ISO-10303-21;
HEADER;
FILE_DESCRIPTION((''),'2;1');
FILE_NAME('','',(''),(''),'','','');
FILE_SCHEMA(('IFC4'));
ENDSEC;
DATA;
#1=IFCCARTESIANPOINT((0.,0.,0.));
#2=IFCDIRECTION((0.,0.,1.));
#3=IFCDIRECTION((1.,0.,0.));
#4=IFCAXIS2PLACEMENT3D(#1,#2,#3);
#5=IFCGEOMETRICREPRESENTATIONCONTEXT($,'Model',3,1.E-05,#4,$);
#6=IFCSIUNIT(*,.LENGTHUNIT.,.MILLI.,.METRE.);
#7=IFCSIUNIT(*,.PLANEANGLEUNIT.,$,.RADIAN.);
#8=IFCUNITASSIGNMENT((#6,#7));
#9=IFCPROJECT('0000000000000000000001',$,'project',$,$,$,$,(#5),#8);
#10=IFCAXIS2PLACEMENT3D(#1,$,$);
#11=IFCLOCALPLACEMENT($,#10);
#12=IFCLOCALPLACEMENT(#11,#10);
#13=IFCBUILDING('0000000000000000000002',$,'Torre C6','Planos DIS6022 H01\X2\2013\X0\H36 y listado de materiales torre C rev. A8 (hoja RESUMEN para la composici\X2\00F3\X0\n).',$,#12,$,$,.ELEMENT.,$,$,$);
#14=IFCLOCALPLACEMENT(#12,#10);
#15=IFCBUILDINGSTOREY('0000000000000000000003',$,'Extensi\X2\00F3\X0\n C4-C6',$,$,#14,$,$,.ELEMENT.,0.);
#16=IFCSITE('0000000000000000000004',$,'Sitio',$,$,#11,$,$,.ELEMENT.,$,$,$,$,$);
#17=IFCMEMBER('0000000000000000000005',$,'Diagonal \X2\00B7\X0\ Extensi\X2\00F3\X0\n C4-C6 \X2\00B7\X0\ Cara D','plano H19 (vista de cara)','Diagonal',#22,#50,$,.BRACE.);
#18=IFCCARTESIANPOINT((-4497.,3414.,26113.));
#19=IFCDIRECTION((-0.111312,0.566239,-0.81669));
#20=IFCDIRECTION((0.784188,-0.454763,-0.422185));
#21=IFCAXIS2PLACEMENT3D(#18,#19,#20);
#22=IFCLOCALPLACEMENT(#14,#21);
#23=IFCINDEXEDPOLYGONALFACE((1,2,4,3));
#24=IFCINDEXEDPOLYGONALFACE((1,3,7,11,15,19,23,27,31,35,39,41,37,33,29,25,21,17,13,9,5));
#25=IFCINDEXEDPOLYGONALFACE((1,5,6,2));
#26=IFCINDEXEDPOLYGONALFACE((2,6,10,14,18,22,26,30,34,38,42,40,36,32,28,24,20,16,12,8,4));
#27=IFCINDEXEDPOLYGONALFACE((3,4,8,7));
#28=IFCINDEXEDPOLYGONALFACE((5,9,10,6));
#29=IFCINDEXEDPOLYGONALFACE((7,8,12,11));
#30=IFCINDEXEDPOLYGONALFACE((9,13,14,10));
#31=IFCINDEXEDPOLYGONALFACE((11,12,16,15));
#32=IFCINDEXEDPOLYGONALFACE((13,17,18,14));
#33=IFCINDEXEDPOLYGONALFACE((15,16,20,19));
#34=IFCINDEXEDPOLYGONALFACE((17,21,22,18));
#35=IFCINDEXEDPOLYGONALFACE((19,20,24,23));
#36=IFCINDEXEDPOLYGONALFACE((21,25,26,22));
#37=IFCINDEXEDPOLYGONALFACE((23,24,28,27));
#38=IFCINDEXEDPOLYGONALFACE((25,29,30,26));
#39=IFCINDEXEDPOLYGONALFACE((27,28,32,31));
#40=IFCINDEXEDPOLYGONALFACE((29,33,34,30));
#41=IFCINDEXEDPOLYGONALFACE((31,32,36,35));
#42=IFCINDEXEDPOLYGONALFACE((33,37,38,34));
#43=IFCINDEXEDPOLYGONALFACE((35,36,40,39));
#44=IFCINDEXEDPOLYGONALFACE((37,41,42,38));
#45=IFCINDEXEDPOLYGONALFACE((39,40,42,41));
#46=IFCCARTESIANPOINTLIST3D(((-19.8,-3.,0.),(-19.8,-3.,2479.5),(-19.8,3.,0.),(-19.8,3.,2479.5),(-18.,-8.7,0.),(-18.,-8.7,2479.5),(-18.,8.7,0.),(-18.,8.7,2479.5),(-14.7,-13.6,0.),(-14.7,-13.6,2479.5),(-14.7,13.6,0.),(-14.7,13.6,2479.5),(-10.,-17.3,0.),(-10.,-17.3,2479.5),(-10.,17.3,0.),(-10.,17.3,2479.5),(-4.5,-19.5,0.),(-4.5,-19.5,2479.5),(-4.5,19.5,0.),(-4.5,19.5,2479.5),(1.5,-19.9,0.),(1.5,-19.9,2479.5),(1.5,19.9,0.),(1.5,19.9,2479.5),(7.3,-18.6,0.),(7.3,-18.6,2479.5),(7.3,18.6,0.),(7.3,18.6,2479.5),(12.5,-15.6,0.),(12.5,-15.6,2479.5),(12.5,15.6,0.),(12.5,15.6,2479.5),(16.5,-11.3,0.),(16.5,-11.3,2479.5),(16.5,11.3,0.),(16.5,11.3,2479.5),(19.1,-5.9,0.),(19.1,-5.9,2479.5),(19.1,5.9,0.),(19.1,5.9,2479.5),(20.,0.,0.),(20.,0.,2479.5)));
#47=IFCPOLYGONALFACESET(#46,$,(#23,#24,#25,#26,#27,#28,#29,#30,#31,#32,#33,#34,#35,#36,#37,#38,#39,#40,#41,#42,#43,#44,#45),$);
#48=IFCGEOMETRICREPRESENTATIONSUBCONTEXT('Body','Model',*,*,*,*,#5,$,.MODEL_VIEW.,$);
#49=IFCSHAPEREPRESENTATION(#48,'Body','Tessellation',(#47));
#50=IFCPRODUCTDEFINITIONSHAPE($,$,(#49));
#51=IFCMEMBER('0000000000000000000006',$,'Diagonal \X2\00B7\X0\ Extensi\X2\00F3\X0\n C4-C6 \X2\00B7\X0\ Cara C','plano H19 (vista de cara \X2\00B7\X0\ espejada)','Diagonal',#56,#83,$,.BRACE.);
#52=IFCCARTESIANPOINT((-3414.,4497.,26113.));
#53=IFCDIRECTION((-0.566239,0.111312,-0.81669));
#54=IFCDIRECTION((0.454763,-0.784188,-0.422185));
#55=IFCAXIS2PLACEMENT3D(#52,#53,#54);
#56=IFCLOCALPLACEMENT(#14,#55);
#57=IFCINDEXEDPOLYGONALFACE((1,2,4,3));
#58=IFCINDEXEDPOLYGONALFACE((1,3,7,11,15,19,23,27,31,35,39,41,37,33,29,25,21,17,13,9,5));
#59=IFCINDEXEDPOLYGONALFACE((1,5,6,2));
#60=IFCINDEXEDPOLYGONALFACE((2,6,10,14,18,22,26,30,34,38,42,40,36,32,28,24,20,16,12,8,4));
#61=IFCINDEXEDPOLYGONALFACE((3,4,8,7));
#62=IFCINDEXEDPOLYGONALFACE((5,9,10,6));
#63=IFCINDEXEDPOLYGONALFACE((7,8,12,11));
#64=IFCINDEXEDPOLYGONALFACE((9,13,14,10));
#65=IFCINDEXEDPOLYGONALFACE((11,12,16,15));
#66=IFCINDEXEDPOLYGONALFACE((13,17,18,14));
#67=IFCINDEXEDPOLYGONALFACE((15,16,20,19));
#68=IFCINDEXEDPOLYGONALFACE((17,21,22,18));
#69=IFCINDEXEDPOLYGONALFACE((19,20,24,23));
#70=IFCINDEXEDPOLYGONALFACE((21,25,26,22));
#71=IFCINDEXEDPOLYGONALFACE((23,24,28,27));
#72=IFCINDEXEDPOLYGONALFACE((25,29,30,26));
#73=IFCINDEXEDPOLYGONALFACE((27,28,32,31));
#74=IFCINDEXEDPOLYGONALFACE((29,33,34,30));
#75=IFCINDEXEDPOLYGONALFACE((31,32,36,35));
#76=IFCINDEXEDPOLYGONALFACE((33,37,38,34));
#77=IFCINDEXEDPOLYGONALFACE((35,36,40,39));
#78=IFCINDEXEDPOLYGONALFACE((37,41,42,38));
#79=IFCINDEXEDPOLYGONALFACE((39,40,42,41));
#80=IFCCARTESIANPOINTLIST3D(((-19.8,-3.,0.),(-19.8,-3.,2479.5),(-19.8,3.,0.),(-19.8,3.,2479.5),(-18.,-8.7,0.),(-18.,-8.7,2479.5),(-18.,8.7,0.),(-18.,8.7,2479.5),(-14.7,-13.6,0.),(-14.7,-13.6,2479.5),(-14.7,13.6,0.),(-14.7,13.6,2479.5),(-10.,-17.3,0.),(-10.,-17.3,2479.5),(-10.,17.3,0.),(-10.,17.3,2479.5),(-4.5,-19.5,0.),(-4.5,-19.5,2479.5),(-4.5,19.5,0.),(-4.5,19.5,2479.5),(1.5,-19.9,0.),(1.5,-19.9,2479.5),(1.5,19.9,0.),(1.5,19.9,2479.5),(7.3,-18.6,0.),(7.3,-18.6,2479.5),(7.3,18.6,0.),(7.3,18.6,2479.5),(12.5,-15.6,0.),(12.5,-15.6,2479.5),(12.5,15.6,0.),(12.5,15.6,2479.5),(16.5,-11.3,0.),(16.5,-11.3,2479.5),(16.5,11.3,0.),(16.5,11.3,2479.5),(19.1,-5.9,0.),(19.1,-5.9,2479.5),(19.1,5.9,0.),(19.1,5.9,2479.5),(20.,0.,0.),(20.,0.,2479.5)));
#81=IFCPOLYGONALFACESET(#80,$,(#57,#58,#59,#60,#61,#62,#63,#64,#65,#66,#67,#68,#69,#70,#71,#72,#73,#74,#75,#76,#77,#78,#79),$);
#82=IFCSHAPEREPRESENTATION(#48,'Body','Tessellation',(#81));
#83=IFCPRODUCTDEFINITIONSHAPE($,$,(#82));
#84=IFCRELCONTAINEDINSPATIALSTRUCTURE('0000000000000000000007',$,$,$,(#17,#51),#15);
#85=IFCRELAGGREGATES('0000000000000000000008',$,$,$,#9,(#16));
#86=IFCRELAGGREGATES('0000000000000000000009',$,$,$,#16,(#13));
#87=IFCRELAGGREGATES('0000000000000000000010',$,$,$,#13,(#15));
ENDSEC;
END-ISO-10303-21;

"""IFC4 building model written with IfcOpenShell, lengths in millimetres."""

from ifc_helpers import new_model, si_unit, frame, origin, origin_with_axes, place, context, subcontext, project, spatial, circle, extrude, element, save


model = new_model("IFC4")

# Units and contexts
model_context = context("Model", 3, precision=1e-05, world=origin_with_axes())
body_context = subcontext(model_context, "Body", "Model", "MODEL_VIEW")
ifc_project = project(units=[si_unit("LENGTHUNIT", "METRE", prefix="MILLI"), si_unit("PLANEANGLEUNIT", "RADIAN")], contexts=[model_context])

# Site, building, storey
site_placement = place(None, origin())
site = spatial("IfcSite", under=ifc_project, at=site_placement, Name="Sitio", CompositionType="ELEMENT")
building_placement = place(site_placement, origin())
building = spatial("IfcBuilding", under=site, at=building_placement, Name="Torre C6", Description="Planos DIS6022 H01–H36 y listado de materiales torre C rev. A8 (hoja RESUMEN para la composición).", CompositionType="ELEMENT")
storey_placement = place(building_placement, origin())
storey = spatial("IfcBuildingStorey", under=building, at=storey_placement, Name="Extensión C4-C6", CompositionType="ELEMENT", Elevation=0.0)

# Members
for number, where, z_axis, x_axis, name, description in (
    (1, (-4497.0, 3414.0, 26113.0), (-0.111312, 0.566239, -0.81669), (0.784188, -0.454763, -0.422185), "Diagonal · Extensión C4-C6 · Cara D", "plano H19 (vista de cara)"),
    (2, (-3414.0, 4497.0, 26113.0), (-0.566239, 0.111312, -0.81669), (0.454763, -0.784188, -0.422185), "Diagonal · Extensión C4-C6 · Cara C", "plano H19 (vista de cara · espejada)"),
):
    element("IfcMember", number, at=place(storey_placement, frame(where, z_axis=z_axis, x_axis=x_axis)), inside=storey, Name=name, Description=description, ObjectType="Diagonal", PredefinedType="BRACE", context=body_context, shape_type="SweptSolid", body=[
        extrude(circle(Radius=20.0), None, (0.0, 0.0, 1.0), 2479.5),
    ])

save(model, "model.ifc")
